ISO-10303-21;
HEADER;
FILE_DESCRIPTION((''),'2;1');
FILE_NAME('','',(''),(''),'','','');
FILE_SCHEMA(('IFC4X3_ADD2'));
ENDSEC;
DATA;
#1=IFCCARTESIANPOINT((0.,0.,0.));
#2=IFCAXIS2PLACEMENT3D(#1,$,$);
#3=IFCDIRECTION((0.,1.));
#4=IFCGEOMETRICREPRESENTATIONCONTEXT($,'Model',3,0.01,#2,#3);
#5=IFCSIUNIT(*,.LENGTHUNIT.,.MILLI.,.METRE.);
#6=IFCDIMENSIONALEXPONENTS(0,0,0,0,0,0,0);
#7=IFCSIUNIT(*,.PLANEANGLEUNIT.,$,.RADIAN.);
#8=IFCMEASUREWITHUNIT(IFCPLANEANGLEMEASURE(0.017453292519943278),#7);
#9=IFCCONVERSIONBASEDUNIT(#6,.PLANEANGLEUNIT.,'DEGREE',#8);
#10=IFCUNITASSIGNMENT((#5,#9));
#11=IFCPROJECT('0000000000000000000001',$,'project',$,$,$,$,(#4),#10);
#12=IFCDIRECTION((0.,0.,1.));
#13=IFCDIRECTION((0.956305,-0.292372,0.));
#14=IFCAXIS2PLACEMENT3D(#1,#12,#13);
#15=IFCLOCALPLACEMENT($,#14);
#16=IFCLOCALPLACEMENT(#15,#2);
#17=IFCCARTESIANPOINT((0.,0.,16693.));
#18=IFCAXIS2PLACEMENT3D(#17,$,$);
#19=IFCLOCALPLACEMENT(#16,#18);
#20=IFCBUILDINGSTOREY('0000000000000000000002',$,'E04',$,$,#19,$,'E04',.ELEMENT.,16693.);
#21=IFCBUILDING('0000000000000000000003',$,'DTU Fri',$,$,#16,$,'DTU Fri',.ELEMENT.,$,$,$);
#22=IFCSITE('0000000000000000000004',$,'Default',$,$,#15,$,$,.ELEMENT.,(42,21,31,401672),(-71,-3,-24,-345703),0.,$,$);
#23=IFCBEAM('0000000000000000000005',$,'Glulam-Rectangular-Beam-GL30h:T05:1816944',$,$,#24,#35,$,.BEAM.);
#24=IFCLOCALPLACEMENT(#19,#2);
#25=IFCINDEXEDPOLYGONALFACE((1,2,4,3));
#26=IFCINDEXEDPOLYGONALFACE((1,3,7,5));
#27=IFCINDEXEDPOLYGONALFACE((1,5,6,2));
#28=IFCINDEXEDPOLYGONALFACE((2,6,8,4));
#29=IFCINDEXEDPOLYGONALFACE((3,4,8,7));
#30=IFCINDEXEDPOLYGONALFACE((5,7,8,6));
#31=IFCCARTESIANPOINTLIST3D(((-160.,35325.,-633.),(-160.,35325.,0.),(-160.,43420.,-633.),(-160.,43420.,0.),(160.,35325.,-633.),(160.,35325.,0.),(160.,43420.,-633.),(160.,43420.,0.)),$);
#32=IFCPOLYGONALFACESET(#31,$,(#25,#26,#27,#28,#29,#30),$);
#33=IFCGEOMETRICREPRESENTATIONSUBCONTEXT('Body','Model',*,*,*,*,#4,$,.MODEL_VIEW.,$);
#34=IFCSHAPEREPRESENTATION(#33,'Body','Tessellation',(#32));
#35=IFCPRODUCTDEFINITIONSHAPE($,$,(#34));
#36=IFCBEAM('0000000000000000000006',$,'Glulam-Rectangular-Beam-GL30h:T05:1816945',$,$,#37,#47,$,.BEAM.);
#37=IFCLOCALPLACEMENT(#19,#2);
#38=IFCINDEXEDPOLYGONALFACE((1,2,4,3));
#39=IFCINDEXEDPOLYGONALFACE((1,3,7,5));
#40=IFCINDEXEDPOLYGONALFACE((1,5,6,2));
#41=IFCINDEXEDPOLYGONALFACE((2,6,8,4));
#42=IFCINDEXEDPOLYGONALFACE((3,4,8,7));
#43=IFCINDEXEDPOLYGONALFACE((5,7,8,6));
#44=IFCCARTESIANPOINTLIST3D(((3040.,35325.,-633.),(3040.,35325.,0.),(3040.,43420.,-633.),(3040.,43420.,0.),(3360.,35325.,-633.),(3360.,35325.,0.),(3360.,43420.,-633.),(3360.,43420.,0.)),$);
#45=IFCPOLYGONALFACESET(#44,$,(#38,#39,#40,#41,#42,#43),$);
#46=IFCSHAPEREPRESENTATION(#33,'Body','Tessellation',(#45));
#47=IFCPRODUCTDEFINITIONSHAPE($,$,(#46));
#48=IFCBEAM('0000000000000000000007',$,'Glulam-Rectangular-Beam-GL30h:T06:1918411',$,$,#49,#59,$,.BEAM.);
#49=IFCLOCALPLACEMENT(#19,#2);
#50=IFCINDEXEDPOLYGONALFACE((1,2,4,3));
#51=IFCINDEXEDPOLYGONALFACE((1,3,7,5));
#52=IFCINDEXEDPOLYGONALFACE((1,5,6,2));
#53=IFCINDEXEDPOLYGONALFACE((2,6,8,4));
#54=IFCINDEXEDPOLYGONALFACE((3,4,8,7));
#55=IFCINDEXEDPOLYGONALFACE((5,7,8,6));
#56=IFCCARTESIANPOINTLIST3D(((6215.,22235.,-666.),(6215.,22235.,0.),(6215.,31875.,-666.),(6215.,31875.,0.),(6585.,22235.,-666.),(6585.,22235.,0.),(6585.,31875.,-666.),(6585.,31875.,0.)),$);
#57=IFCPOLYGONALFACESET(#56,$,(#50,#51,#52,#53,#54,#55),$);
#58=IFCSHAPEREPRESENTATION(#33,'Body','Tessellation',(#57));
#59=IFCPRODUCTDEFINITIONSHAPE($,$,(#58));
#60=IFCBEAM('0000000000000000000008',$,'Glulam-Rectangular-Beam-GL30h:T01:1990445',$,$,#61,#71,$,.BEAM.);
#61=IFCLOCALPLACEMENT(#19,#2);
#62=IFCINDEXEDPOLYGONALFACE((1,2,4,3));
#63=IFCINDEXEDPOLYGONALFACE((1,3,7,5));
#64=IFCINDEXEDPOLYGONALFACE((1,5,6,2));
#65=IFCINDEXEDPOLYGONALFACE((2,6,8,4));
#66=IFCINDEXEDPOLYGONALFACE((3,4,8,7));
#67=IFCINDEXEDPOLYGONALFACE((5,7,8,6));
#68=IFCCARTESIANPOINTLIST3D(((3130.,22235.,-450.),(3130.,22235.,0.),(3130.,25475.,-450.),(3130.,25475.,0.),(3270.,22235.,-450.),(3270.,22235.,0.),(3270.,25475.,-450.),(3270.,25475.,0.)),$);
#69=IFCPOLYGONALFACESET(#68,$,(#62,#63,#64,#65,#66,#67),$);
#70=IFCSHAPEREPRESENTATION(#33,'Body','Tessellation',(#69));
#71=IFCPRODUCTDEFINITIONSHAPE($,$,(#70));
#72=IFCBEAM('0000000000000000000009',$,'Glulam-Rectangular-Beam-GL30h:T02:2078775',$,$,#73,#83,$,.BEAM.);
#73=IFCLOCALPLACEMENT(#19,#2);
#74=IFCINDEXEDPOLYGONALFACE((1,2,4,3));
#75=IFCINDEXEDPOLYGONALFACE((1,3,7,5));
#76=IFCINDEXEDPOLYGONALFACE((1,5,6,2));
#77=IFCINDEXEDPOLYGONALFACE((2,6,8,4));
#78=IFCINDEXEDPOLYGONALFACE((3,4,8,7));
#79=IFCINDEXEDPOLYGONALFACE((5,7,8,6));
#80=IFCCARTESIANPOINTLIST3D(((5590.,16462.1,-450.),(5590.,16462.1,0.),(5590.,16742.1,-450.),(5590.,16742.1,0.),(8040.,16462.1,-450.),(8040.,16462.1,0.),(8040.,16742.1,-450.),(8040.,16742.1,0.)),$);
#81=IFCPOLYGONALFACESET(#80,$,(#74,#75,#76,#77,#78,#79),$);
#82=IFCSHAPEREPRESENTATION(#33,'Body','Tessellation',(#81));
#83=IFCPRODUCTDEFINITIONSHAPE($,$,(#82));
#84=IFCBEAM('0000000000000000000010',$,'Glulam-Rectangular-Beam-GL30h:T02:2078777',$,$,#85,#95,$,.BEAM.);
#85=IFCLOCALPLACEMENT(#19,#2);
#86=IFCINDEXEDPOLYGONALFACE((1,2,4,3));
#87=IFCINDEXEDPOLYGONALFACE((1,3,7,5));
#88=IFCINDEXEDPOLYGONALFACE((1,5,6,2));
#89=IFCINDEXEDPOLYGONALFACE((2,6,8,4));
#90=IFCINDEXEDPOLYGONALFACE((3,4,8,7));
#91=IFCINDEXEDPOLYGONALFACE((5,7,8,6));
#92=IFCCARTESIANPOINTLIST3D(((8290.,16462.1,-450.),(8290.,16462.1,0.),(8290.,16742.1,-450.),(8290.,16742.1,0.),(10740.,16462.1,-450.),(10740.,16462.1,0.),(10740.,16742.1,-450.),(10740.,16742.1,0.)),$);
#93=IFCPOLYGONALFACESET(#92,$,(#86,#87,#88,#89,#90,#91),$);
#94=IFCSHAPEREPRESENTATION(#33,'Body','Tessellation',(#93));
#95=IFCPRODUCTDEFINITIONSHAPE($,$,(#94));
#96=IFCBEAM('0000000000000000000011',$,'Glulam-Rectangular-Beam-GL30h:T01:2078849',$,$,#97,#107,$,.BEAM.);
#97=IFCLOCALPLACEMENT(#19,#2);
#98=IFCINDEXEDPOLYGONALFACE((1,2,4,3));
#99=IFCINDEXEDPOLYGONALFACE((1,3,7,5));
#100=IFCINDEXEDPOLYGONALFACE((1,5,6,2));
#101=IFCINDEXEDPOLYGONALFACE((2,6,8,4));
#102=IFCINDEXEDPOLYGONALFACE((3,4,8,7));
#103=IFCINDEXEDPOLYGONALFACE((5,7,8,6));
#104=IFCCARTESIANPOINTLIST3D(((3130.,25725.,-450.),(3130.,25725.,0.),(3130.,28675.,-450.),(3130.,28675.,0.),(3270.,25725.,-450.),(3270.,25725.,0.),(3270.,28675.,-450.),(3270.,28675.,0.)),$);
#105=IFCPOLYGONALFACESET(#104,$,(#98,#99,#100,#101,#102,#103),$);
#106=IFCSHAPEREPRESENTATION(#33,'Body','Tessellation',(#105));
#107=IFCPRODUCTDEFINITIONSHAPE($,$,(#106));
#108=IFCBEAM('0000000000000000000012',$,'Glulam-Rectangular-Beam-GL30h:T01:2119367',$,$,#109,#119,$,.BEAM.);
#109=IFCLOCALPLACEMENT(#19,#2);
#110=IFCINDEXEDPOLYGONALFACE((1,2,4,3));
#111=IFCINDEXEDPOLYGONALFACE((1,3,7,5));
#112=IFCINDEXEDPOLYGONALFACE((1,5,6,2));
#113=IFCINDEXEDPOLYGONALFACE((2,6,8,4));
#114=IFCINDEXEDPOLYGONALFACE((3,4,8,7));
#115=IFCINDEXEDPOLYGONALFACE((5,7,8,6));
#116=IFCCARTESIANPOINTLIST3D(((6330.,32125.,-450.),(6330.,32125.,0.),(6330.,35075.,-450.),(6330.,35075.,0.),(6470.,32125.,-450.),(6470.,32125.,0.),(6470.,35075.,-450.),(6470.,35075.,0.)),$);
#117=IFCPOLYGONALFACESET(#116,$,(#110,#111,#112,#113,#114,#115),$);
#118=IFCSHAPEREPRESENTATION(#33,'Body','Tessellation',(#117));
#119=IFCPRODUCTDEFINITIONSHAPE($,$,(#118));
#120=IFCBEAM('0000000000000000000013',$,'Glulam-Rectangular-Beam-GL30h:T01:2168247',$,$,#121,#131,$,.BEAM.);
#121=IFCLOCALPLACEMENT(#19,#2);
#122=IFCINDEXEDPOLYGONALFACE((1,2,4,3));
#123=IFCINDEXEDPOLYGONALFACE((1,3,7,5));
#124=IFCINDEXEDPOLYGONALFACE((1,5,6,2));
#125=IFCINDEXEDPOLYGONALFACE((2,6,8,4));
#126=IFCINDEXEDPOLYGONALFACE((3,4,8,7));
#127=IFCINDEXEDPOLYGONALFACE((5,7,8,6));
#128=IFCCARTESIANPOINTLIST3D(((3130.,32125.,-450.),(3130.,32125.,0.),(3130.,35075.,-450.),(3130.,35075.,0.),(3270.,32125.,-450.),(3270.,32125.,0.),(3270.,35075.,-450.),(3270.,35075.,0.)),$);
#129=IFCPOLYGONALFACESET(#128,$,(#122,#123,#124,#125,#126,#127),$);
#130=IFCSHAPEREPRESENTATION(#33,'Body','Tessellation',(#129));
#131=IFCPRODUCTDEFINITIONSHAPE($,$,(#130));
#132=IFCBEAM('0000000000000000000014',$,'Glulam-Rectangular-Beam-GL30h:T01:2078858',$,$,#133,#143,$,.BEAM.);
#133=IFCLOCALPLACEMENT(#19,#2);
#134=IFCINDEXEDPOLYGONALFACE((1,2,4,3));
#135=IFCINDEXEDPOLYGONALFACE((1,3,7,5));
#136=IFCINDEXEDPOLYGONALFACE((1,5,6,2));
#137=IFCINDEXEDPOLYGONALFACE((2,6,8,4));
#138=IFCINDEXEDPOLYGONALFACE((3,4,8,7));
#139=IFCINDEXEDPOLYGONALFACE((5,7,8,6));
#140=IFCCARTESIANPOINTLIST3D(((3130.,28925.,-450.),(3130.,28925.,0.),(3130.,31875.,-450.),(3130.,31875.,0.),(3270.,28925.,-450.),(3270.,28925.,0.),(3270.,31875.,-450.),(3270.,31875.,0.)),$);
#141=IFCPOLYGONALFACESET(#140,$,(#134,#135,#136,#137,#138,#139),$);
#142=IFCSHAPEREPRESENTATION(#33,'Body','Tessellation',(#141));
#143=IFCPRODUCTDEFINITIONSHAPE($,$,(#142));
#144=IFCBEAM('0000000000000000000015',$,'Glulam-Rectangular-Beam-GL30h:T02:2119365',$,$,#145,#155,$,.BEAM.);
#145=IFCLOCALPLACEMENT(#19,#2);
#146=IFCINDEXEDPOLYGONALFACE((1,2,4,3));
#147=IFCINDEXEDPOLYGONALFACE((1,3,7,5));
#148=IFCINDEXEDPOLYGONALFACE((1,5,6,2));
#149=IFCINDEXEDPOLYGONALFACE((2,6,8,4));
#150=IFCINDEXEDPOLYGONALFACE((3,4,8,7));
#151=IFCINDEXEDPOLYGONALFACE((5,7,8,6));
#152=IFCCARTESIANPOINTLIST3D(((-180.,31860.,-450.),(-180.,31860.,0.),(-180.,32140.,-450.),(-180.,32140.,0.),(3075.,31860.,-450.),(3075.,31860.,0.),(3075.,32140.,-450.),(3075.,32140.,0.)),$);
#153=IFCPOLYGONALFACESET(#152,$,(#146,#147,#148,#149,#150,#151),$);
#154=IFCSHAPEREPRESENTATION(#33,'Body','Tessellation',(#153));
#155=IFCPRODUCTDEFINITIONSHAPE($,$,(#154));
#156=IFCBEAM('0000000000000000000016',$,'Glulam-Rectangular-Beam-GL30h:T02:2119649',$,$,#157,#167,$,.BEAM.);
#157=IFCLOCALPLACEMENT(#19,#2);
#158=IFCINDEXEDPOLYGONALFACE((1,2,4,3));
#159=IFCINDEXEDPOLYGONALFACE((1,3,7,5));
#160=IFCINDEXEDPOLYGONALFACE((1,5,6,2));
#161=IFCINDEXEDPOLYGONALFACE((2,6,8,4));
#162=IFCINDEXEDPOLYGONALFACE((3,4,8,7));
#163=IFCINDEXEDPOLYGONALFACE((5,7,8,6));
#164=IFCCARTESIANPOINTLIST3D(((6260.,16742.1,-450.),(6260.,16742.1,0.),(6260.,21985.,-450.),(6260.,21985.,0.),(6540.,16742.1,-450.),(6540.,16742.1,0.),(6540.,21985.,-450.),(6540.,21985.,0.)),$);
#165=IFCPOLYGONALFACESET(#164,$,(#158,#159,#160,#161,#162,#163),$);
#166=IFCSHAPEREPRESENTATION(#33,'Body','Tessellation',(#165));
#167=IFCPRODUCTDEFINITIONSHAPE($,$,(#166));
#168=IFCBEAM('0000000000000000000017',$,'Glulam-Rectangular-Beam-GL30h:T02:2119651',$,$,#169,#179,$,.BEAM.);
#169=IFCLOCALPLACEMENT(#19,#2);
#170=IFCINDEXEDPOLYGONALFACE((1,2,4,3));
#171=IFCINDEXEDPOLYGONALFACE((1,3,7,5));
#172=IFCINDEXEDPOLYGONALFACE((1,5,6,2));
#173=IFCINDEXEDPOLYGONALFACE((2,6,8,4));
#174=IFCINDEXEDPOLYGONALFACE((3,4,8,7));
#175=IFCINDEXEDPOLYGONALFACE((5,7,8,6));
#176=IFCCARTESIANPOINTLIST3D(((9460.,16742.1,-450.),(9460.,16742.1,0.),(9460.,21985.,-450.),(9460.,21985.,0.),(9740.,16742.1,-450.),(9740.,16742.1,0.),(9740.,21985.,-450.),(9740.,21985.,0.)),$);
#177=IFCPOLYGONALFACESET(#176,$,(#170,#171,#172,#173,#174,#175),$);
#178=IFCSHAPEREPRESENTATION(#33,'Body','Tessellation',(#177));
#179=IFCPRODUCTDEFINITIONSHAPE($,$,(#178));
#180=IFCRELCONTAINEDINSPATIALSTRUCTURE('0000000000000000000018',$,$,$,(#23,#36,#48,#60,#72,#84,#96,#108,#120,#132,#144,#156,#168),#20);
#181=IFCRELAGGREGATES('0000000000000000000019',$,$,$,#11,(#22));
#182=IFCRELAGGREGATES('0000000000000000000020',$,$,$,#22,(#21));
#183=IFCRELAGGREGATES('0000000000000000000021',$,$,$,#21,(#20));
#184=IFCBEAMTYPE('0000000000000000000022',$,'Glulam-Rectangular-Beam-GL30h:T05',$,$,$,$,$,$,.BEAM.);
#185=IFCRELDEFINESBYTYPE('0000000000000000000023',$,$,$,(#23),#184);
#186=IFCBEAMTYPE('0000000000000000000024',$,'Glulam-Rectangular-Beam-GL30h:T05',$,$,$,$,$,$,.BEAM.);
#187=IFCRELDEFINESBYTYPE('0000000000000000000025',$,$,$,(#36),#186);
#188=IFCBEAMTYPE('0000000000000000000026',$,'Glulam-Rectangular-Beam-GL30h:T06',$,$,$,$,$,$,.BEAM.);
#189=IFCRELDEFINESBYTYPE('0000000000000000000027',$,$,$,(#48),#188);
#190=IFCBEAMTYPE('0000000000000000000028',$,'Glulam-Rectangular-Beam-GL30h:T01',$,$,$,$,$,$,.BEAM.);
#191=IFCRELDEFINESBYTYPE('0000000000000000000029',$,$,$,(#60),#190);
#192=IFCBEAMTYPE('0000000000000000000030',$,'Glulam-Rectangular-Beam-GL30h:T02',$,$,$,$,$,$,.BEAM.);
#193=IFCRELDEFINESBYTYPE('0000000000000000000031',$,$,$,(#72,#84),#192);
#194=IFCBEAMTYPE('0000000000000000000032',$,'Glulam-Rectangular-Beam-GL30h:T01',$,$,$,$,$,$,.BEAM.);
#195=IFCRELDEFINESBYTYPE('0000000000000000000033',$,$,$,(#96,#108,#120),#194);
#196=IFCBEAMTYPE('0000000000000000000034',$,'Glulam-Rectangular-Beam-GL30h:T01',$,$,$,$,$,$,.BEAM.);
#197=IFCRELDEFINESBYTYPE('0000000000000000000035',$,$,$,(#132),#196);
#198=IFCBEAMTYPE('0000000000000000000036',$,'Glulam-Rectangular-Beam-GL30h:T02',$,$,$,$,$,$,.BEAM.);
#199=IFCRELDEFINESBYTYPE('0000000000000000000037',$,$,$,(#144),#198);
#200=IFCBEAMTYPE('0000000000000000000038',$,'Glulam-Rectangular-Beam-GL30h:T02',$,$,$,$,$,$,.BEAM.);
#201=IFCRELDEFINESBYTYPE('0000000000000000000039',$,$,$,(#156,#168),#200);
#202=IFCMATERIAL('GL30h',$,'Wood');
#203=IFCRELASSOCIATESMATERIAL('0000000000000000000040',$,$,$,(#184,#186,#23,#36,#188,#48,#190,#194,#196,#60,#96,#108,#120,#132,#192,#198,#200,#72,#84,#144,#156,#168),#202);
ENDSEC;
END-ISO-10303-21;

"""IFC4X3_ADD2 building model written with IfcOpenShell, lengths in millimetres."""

from ifc_helpers import new_model, entity, si_unit, converted_unit, direction, frame, origin, origin_2d_with_axis, place, context, subcontext, project, spatial, rectangle, extrude, source, transform, mapped, material, material_profile, profile_set, profile_usage, type_object, type_shapes, element, save


model = new_model("IFC4X3_ADD2")

# Units and contexts
model_context = context("Model", 3, precision=0.01, world=origin(), true_north=direction((0.0, 1.0)))
body_context = subcontext(model_context, "Body", "Model", "MODEL_VIEW")
ifc_project = project(units=[si_unit("LENGTHUNIT", "METRE", prefix="MILLI"), converted_unit("PLANEANGLEUNIT", "DEGREE", entity("IfcPlaneAngleMeasure", 0.017453292519943278), si_unit("PLANEANGLEUNIT", "RADIAN"), dimensions=[0, 0, 0, 0, 0, 0, 0])], contexts=[model_context])

# Site, building, storey
site_placement = place(None, frame((0.0, 0.0, 0.0), z_axis=(0.0, 0.0, 1.0), x_axis=(0.956305, -0.292372, 0.0)))
site = spatial("IfcSite", under=ifc_project, at=site_placement, Name="Default", CompositionType="ELEMENT", RefLatitude=(42, 21, 31, 401672), RefLongitude=(-71, -3, -24, -345703), RefElevation=0.0)
building_placement = place(site_placement, origin())
building = spatial("IfcBuilding", under=site, at=building_placement, Name="DTU Fri", LongName="DTU Fri", CompositionType="ELEMENT")
storey_placement = place(building_placement, frame((0.0, 0.0, 16693.0)))
storey = spatial("IfcBuildingStorey", under=building, at=storey_placement, Name="E04", LongName="E04", CompositionType="ELEMENT", Elevation=16693.0)

# Beams
ifc_material_1 = material(Name="GL30h", Category="Wood")
ifc_material_profile_1 = material_profile(ifc_material_1, rectangle(XDim=633.0, YDim=320.0, at=origin_2d_with_axis()), Name="T05")
ifc_profile_set_1 = profile_set([ifc_material_profile_1], Name="T05")
ifc_profile_usage_1 = profile_usage(ifc_profile_set_1, cardinal=8)
beam_type_1 = type_object("IfcBeamType", Name="Glulam-Rectangular-Beam-GL30h:T05", PredefinedType="BEAM", material=ifc_profile_set_1)
shared_shape_1 = source(origin(), body_context, "Body", "SweptSolid", [
    extrude(rectangle(XDim=633.0, YDim=320.0, at=origin_2d_with_axis()), frame((-4060.0, 0.0, 0.0), z_axis=(1.0, 0.0, 0.0), x_axis=(0.0, 0.0, -1.0)), (0.0, 0.0, 1.0), 8095.0),
])
type_shapes(beam_type_1, [shared_shape_1])
beam_1_placement = place(storey_placement, frame((0.0, 39360.0, -316.5), z_axis=(0.0, 0.0, 1.0), x_axis=(0.0, -1.0, 0.0)))
element("IfcBeam", 1, at=beam_1_placement, inside=storey, type_object=beam_type_1, material=ifc_profile_usage_1, Name="Glulam-Rectangular-Beam-GL30h:T05:1816944", PredefinedType="BEAM", context=body_context, shape_type="MappedRepresentation", body=[
    mapped(shared_shape_1, transform((0.0, 0.0, 0.0), scale=1.0)),
])
beam_type_2 = type_object("IfcBeamType", Name="Glulam-Rectangular-Beam-GL30h:T05", PredefinedType="BEAM", material=ifc_profile_set_1)
shared_shape_2 = source(origin(), body_context, "Body", "SweptSolid", [
    extrude(rectangle(XDim=633.0, YDim=320.0, at=origin_2d_with_axis()), frame((-4060.0, 0.0, 0.0), z_axis=(1.0, 0.0, 0.0), x_axis=(0.0, 0.0, -1.0)), (0.0, 0.0, 1.0), 8095.0),
])
type_shapes(beam_type_2, [shared_shape_2])
beam_2_placement = place(storey_placement, frame((3200.0, 39360.0, -316.5), z_axis=(0.0, 0.0, 1.0), x_axis=(0.0, -1.0, 0.0)))
element("IfcBeam", 2, at=beam_2_placement, inside=storey, type_object=beam_type_2, material=ifc_profile_usage_1, Name="Glulam-Rectangular-Beam-GL30h:T05:1816945", PredefinedType="BEAM", context=body_context, shape_type="MappedRepresentation", body=[
    mapped(shared_shape_2, transform((0.0, 0.0, 0.0), scale=1.0)),
])
ifc_material_profile_2 = material_profile(ifc_material_1, rectangle(XDim=666.0, YDim=370.0, at=origin_2d_with_axis()), Name="T06")
ifc_profile_set_2 = profile_set([ifc_material_profile_2], Name="T06")
ifc_profile_usage_2 = profile_usage(ifc_profile_set_2, cardinal=8)
beam_type_3 = type_object("IfcBeamType", Name="Glulam-Rectangular-Beam-GL30h:T06", PredefinedType="BEAM", material=ifc_profile_set_2)
shared_shape_3 = source(origin(), body_context, "Body", "SweptSolid", [
    extrude(rectangle(XDim=666.0, YDim=370.0, at=origin_2d_with_axis()), frame((-4820.0, 0.0, 0.0), z_axis=(1.0, 0.0, 0.0), x_axis=(0.0, 0.0, -1.0)), (0.0, 0.0, 1.0), 9640.0),
])
type_shapes(beam_type_3, [shared_shape_3])
beam_3_placement = place(storey_placement, frame((6400.0, 27055.0, -333.0), z_axis=(0.0, 0.0, 1.0), x_axis=(0.0, -1.0, 0.0)))
element("IfcBeam", 3, at=beam_3_placement, inside=storey, type_object=beam_type_3, material=ifc_profile_usage_2, Name="Glulam-Rectangular-Beam-GL30h:T06:1918411", PredefinedType="BEAM", context=body_context, shape_type="MappedRepresentation", body=[
    mapped(shared_shape_3, transform((0.0, 0.0, 0.0), scale=1.0)),
])
ifc_material_profile_3 = material_profile(ifc_material_1, rectangle(XDim=450.0, YDim=140.0, at=origin_2d_with_axis()), Name="T01")
ifc_profile_set_3 = profile_set([ifc_material_profile_3], Name="T01")
ifc_profile_usage_3 = profile_usage(ifc_profile_set_3, cardinal=8)
beam_type_4 = type_object("IfcBeamType", Name="Glulam-Rectangular-Beam-GL30h:T01", PredefinedType="BEAM", material=ifc_profile_set_3)
shared_shape_4 = source(origin(), body_context, "Body", "SweptSolid", [
    extrude(rectangle(XDim=450.0, YDim=140.0, at=origin_2d_with_axis()), frame((-1620.0, 0.0, 0.0), z_axis=(1.0, 0.0, 0.0), x_axis=(0.0, 0.0, -1.0)), (0.0, 0.0, 1.0), 3240.0),
])
type_shapes(beam_type_4, [shared_shape_4])
beam_4_placement = place(storey_placement, frame((3200.0, 23855.0, -225.0), z_axis=(0.0, 0.0, 1.0), x_axis=(0.0, -1.0, 0.0)))
element("IfcBeam", 4, at=beam_4_placement, inside=storey, type_object=beam_type_4, material=ifc_profile_usage_3, Name="Glulam-Rectangular-Beam-GL30h:T01:1990445", PredefinedType="BEAM", context=body_context, shape_type="MappedRepresentation", body=[
    mapped(shared_shape_4, transform((0.0, 0.0, 0.0), scale=1.0)),
])
ifc_material_profile_4 = material_profile(ifc_material_1, rectangle(XDim=450.0, YDim=280.0, at=origin_2d_with_axis()), Name="T02")
ifc_profile_set_4 = profile_set([ifc_material_profile_4], Name="T02")
ifc_profile_usage_4 = profile_usage(ifc_profile_set_4, cardinal=8)
beam_type_5 = type_object("IfcBeamType", Name="Glulam-Rectangular-Beam-GL30h:T02", PredefinedType="BEAM", material=ifc_profile_set_4)
shared_shape_5 = source(origin(), body_context, "Body", "SweptSolid", [
    extrude(rectangle(XDim=450.0, YDim=280.0, at=origin_2d_with_axis()), frame((-1225.0, 0.0, 0.0), z_axis=(1.0, 0.0, 0.0), x_axis=(0.0, 0.0, -1.0)), (0.0, 0.0, 1.0), 2450.0),
])
type_shapes(beam_type_5, [shared_shape_5])
for number, where, z_axis, x_axis, name in (
    (5, (6815.0, 16602.1, -225.0), (0.0, 0.0, 1.0), (-1.0, 0.0, 0.0), "Glulam-Rectangular-Beam-GL30h:T02:2078775"),
    (6, (9515.0, 16602.1, -225.0), (0.0, 0.0, 1.0), (-1.0, 0.0, 0.0), "Glulam-Rectangular-Beam-GL30h:T02:2078777"),
):
    element("IfcBeam", number, at=place(storey_placement, frame(where, z_axis=z_axis, x_axis=x_axis)), inside=storey, type_object=beam_type_5, material=ifc_profile_usage_4, Name=name, PredefinedType="BEAM", context=body_context, shape_type="MappedRepresentation", body=[
        mapped(shared_shape_5, transform((0.0, 0.0, 0.0), scale=1.0)),
    ])
beam_type_6 = type_object("IfcBeamType", Name="Glulam-Rectangular-Beam-GL30h:T01", PredefinedType="BEAM", material=ifc_profile_set_3)
shared_shape_6 = source(origin(), body_context, "Body", "SweptSolid", [
    extrude(rectangle(XDim=450.0, YDim=140.0, at=origin_2d_with_axis()), frame((-1475.0, 0.0, 0.0), z_axis=(1.0, 0.0, 0.0), x_axis=(0.0, 0.0, -1.0)), (0.0, 0.0, 1.0), 2950.0),
])
type_shapes(beam_type_6, [shared_shape_6])
for number, where, z_axis, x_axis, name in (
    (7, (3200.0, 27200.0, -225.0), (0.0, 0.0, 1.0), (0.0, -1.0, 0.0), "Glulam-Rectangular-Beam-GL30h:T01:2078849"),
    (8, (6400.0, 33600.0, -225.0), (0.0, 0.0, 1.0), (0.0, 1.0, 0.0), "Glulam-Rectangular-Beam-GL30h:T01:2119367"),
    (9, (3200.0, 33600.0, -225.0), (0.0, 0.0, 1.0), (0.0, 1.0, 0.0), "Glulam-Rectangular-Beam-GL30h:T01:2168247"),
):
    element("IfcBeam", number, at=place(storey_placement, frame(where, z_axis=z_axis, x_axis=x_axis)), inside=storey, type_object=beam_type_6, material=ifc_profile_usage_3, Name=name, PredefinedType="BEAM", context=body_context, shape_type="MappedRepresentation", body=[
        mapped(shared_shape_6, transform((0.0, 0.0, 0.0), scale=1.0)),
    ])
beam_type_7 = type_object("IfcBeamType", Name="Glulam-Rectangular-Beam-GL30h:T01", PredefinedType="BEAM", material=ifc_profile_set_3)
shared_shape_7 = source(origin(), body_context, "Body", "SweptSolid", [
    extrude(rectangle(XDim=450.0, YDim=140.0, at=origin_2d_with_axis()), frame((-1465.0, 0.0, 0.0), z_axis=(1.0, 0.0, 0.0), x_axis=(0.0, 0.0, -1.0)), (0.0, 0.0, 1.0), 2950.0),
])
type_shapes(beam_type_7, [shared_shape_7])
beam_5_placement = place(storey_placement, frame((3200.0, 30410.0, -225.0), z_axis=(0.0, 0.0, 1.0), x_axis=(0.0, -1.0, 0.0)))
element("IfcBeam", 10, at=beam_5_placement, inside=storey, type_object=beam_type_7, material=ifc_profile_usage_3, Name="Glulam-Rectangular-Beam-GL30h:T01:2078858", PredefinedType="BEAM", context=body_context, shape_type="MappedRepresentation", body=[
    mapped(shared_shape_7, transform((0.0, 0.0, 0.0), scale=1.0)),
])
beam_type_8 = type_object("IfcBeamType", Name="Glulam-Rectangular-Beam-GL30h:T02", PredefinedType="BEAM", material=ifc_profile_set_4)
shared_shape_8 = source(origin(), body_context, "Body", "SweptSolid", [
    extrude(rectangle(XDim=450.0, YDim=280.0, at=origin_2d_with_axis()), frame((-1640.0, 0.0, 0.0), z_axis=(1.0, 0.0, 0.0), x_axis=(0.0, 0.0, -1.0)), (0.0, 0.0, 1.0), 3255.0),
])
type_shapes(beam_type_8, [shared_shape_8])
beam_6_placement = place(storey_placement, frame((1435.0, 32000.0, -225.0), z_axis=(0.0, 0.0, 1.0), x_axis=(-1.0, 0.0, 0.0)))
element("IfcBeam", 11, at=beam_6_placement, inside=storey, type_object=beam_type_8, material=ifc_profile_usage_4, Name="Glulam-Rectangular-Beam-GL30h:T02:2119365", PredefinedType="BEAM", context=body_context, shape_type="MappedRepresentation", body=[
    mapped(shared_shape_8, transform((0.0, 0.0, 0.0), scale=1.0)),
])
beam_type_9 = type_object("IfcBeamType", Name="Glulam-Rectangular-Beam-GL30h:T02", PredefinedType="BEAM", material=ifc_profile_set_4)
shared_shape_9 = source(origin(), body_context, "Body", "SweptSolid", [
    extrude(rectangle(XDim=450.0, YDim=280.0, at=origin_2d_with_axis()), frame((-2614.0, 0.0, 0.0), z_axis=(1.0, 0.0, 0.0), x_axis=(0.0, 0.0, -1.0)), (0.0, 0.0, 1.0), 5242.9),
])
type_shapes(beam_type_9, [shared_shape_9])
for number, where, z_axis, x_axis, name in (
    (12, (6400.0, 19356.0, -225.0), (0.0, 0.0, 1.0), (0.0, 1.0, 0.0), "Glulam-Rectangular-Beam-GL30h:T02:2119649"),
    (13, (9600.0, 19356.0, -225.0), (0.0, 0.0, 1.0), (0.0, 1.0, 0.0), "Glulam-Rectangular-Beam-GL30h:T02:2119651"),
):
    element("IfcBeam", number, at=place(storey_placement, frame(where, z_axis=z_axis, x_axis=x_axis)), inside=storey, type_object=beam_type_9, material=ifc_profile_usage_4, Name=name, PredefinedType="BEAM", context=body_context, shape_type="MappedRepresentation", body=[
        mapped(shared_shape_9, transform((0.0, 0.0, 0.0), scale=1.0)),
    ])

save(model, "model.ifc")
